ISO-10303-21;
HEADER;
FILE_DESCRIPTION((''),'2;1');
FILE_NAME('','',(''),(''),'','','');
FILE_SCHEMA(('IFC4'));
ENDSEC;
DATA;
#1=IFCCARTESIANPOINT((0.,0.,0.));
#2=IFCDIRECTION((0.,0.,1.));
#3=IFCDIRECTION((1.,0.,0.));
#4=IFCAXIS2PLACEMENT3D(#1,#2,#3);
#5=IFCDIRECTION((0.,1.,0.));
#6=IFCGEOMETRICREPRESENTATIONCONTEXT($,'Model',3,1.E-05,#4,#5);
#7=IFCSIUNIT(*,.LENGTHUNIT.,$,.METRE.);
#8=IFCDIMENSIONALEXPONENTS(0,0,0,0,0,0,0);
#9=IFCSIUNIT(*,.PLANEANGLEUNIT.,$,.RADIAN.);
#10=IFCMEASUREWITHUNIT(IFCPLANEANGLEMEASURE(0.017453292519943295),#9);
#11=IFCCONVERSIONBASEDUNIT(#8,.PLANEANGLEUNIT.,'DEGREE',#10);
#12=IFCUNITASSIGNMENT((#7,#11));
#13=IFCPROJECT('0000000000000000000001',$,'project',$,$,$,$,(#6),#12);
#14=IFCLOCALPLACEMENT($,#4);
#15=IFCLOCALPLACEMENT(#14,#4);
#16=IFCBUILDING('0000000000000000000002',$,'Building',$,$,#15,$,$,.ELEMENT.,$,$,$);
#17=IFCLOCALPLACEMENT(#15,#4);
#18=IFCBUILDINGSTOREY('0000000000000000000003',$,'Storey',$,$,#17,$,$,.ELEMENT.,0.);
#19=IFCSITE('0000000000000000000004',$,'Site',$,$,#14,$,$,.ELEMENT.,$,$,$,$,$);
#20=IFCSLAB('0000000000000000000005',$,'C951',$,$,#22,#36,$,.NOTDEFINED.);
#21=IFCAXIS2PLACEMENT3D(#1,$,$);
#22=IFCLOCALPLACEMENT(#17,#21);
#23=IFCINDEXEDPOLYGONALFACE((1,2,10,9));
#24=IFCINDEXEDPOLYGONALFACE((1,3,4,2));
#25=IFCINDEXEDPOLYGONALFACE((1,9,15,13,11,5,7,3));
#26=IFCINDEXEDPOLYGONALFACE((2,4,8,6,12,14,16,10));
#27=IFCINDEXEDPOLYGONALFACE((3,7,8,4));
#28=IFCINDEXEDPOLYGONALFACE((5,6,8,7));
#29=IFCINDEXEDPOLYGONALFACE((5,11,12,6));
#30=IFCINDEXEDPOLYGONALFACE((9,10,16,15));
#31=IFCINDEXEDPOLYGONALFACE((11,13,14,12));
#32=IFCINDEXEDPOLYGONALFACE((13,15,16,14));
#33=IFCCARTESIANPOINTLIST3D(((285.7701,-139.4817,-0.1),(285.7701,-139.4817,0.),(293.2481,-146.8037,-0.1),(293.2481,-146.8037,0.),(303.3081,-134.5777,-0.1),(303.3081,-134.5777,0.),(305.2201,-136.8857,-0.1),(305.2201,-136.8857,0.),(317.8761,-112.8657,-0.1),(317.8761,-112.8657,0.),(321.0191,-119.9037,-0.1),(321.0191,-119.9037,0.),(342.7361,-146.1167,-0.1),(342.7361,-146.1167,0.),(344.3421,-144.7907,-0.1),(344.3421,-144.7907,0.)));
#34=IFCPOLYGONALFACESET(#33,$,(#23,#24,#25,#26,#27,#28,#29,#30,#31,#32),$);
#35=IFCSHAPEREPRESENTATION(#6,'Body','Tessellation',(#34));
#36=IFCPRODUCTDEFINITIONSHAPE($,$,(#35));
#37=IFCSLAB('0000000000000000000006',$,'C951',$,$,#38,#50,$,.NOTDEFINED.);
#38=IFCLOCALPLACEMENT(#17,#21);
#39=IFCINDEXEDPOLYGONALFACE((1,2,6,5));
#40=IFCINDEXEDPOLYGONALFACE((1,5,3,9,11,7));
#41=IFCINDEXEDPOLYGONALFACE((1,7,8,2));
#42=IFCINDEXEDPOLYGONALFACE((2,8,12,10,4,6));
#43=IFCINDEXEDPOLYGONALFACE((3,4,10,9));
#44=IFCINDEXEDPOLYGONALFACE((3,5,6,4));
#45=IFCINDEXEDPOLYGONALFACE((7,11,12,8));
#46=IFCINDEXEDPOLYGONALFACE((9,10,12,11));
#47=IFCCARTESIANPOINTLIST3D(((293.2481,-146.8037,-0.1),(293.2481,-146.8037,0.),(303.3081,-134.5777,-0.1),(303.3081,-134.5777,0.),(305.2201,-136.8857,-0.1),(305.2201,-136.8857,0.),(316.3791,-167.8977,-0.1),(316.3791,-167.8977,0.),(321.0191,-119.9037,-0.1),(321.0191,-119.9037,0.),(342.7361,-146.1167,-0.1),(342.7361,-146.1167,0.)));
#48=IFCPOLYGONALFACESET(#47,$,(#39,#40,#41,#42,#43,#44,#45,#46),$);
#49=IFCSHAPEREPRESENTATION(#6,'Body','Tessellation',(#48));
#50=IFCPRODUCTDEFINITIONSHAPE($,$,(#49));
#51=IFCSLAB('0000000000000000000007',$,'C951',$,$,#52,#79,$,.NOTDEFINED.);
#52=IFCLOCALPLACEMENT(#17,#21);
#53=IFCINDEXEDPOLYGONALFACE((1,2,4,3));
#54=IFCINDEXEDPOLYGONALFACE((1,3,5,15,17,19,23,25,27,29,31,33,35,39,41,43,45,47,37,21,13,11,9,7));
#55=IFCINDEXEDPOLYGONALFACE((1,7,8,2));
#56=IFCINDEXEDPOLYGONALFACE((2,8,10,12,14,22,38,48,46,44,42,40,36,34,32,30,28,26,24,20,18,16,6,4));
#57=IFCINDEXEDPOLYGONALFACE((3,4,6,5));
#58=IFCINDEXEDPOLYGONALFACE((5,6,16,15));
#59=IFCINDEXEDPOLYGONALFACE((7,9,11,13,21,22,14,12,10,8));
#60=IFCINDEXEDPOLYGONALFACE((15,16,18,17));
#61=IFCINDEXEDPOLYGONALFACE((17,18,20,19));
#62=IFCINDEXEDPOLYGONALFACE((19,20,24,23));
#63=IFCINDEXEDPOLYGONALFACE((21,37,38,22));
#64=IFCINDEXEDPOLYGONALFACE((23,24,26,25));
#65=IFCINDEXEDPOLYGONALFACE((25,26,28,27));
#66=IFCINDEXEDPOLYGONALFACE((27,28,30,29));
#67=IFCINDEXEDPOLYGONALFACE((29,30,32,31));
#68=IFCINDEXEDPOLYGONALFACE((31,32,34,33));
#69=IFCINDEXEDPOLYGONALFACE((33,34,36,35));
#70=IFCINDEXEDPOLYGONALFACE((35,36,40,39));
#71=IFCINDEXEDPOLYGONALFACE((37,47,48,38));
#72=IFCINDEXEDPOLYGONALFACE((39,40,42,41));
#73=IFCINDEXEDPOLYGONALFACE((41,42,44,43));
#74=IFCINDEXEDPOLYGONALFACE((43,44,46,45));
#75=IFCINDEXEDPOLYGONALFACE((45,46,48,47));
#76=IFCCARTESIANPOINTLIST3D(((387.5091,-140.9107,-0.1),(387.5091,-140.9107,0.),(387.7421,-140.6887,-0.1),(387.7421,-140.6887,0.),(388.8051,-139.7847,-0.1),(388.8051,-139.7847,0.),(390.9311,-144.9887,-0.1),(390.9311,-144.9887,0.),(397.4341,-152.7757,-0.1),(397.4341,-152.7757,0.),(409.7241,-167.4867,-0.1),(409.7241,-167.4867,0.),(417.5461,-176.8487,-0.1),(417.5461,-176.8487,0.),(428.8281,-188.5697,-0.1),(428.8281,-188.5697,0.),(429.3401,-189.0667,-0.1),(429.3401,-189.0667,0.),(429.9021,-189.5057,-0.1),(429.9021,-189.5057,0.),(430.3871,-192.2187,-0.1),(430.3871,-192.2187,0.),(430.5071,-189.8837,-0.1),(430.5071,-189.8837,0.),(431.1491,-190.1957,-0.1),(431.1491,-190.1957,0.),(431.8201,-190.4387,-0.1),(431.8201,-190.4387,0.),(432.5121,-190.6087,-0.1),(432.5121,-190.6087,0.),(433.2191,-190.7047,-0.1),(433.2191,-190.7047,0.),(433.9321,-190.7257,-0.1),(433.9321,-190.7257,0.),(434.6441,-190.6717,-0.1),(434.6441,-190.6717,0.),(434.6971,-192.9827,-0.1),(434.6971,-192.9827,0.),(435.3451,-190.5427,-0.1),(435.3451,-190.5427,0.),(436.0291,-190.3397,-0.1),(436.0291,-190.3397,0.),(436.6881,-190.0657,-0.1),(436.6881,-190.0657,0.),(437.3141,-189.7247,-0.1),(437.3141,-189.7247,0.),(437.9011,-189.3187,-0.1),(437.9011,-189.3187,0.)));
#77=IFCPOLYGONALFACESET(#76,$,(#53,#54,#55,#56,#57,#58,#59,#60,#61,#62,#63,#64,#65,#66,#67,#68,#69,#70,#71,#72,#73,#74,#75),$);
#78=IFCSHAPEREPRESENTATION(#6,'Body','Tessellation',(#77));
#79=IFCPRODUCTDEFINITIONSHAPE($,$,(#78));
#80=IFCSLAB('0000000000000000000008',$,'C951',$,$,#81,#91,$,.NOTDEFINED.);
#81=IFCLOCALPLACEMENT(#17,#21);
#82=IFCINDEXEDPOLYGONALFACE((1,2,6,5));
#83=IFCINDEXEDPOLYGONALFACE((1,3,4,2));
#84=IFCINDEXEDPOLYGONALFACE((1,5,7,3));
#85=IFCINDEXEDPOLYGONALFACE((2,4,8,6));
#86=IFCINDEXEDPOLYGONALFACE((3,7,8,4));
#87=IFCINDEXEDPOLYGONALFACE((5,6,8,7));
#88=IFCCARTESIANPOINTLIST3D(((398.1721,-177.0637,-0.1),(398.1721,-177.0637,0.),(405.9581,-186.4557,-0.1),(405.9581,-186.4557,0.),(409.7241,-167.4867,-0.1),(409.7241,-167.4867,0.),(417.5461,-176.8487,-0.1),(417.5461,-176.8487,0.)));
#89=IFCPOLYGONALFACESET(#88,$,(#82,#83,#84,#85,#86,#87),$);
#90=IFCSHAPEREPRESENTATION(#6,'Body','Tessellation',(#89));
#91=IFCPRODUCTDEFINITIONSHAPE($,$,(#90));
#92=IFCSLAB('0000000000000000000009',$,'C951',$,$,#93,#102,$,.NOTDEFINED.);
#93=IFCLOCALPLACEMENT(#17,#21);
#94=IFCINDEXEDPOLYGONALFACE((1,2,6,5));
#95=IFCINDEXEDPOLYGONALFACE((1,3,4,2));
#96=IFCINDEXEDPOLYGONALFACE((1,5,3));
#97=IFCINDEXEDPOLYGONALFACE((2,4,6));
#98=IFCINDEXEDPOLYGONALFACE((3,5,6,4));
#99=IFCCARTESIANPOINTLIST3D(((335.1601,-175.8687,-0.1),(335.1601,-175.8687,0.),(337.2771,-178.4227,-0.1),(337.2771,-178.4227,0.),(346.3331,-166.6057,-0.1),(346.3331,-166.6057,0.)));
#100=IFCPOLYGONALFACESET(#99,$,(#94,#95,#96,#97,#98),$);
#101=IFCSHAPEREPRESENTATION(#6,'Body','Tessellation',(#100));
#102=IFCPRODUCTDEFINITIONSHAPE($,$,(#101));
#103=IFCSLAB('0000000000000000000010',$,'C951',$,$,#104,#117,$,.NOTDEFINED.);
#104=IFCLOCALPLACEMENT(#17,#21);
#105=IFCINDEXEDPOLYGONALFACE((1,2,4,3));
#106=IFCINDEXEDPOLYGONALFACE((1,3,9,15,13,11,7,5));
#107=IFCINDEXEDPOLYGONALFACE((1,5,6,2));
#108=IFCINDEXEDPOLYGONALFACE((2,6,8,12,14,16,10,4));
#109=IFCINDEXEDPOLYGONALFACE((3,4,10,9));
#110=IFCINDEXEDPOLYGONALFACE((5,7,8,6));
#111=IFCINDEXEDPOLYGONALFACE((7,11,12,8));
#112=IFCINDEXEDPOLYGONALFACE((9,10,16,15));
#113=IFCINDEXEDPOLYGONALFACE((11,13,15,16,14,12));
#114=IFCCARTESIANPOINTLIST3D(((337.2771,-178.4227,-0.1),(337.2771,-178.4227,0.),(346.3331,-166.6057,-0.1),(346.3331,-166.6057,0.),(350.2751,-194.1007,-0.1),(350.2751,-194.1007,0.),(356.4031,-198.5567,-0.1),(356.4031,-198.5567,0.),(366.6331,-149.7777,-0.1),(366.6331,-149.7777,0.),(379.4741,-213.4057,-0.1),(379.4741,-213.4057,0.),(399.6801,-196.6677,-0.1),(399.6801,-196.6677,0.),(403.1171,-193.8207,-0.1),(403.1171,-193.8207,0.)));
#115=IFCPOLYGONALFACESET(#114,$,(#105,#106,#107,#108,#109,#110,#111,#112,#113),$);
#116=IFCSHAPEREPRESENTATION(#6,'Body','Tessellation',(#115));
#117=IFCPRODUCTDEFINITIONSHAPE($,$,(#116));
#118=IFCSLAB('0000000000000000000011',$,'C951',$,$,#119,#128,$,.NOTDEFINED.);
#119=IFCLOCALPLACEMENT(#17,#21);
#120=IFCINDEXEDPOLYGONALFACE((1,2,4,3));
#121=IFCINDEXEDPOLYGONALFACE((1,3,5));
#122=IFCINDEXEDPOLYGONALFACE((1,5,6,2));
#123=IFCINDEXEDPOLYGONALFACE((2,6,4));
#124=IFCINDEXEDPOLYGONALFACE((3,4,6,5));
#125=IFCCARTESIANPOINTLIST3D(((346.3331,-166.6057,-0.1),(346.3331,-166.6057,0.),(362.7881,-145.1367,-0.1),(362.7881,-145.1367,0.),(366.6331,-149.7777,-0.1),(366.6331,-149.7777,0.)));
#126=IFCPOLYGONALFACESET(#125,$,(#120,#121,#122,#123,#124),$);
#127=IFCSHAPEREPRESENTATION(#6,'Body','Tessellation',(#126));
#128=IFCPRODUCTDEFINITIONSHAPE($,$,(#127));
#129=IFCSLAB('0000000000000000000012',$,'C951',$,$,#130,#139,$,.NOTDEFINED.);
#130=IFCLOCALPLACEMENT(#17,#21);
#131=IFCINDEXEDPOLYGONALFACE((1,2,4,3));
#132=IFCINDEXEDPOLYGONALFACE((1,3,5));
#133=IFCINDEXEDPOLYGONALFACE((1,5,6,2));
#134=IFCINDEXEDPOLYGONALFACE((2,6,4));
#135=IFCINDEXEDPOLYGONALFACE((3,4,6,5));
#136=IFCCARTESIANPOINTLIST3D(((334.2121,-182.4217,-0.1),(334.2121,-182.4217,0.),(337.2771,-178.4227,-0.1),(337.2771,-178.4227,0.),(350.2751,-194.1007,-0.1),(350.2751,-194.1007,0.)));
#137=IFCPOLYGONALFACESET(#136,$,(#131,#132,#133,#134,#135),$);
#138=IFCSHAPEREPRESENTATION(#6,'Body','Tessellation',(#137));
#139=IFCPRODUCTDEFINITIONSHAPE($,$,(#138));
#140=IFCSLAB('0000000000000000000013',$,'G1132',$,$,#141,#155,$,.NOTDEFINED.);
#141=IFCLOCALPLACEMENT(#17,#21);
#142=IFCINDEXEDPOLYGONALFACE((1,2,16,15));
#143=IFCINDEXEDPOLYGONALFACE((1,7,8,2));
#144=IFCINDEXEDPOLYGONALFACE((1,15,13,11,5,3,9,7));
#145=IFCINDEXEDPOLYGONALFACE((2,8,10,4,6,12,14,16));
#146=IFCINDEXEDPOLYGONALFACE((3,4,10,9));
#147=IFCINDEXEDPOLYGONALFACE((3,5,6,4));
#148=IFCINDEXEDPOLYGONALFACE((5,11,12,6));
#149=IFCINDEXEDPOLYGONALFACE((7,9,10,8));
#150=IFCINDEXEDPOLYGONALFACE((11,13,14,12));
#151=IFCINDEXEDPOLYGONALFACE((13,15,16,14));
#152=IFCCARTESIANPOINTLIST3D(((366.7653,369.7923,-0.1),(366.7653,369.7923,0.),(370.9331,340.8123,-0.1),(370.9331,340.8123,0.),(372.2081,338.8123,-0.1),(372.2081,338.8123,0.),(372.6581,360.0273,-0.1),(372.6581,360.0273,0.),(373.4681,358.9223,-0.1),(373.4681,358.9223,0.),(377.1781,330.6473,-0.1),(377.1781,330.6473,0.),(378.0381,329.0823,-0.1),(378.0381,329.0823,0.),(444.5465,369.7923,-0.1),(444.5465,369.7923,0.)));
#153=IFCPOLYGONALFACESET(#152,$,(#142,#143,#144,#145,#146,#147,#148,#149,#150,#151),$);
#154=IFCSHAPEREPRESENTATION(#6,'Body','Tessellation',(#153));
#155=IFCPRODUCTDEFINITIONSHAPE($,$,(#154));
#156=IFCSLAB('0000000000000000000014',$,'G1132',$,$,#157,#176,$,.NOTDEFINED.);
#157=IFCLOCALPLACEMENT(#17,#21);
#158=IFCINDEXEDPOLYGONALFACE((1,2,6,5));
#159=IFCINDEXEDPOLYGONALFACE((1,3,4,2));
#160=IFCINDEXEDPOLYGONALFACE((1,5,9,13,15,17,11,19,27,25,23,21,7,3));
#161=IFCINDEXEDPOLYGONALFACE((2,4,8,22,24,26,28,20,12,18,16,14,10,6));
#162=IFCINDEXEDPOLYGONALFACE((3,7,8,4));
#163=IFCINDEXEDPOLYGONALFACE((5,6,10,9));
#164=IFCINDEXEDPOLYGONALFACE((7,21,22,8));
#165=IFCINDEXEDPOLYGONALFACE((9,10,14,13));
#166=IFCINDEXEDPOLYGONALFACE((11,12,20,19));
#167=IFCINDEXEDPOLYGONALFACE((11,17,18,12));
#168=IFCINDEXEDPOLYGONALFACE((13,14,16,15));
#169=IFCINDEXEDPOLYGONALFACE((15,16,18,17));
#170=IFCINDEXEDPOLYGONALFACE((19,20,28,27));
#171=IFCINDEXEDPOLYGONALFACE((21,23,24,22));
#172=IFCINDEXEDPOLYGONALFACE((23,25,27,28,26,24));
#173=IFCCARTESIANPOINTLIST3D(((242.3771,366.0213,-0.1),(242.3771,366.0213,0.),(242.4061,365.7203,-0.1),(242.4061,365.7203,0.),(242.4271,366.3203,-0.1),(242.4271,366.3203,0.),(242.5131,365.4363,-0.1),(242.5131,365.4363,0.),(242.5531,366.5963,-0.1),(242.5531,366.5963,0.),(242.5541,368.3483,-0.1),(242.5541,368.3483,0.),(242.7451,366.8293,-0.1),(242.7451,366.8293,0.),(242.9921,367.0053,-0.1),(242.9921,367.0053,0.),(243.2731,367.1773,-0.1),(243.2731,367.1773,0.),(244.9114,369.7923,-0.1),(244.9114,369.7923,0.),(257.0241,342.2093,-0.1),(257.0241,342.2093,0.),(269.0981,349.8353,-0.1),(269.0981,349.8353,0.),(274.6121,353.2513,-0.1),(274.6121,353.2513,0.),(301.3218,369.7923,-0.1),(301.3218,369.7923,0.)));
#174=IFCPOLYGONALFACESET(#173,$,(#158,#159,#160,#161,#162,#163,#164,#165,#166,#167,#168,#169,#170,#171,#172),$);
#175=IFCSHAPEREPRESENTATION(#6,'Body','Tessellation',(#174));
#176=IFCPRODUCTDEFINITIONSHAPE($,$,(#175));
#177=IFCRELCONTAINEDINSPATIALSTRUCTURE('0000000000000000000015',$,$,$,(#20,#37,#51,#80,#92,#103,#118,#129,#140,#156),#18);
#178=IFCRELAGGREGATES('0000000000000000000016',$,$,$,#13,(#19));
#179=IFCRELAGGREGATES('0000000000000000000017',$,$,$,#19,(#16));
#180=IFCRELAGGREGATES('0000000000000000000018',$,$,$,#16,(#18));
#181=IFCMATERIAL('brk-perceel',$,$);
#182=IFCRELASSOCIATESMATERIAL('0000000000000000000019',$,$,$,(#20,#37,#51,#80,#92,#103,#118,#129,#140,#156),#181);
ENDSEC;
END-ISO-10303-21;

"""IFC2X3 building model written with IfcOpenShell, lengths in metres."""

from ifc_helpers import new_model, entity, si_unit, converted_unit, direction, frame, origin_with_axes, place, context, project, spatial, polyline, outline, extrude, material, element, save


model = new_model("IFC2X3")

# Units and contexts
model_context = context("Model", 3, precision=1e-05, world=origin_with_axes(), true_north=direction((0.0, 1.0, 0.0)))
ifc_project = project(units=[si_unit("LENGTHUNIT", "METRE"), converted_unit("PLANEANGLEUNIT", "DEGREE", entity("IfcPlaneAngleMeasure", 0.017453292519943295), si_unit("PLANEANGLEUNIT", "RADIAN"), dimensions=[0, 0, 0, 0, 0, 0, 0])], contexts=[model_context])

# Site, building, storey
site_placement = place(None, origin_with_axes())
site = spatial("IfcSite", under=ifc_project, at=site_placement, Name="Site", CompositionType="ELEMENT")
building_placement = place(site_placement, origin_with_axes())
building = spatial("IfcBuilding", under=site, at=building_placement, Name="Building", CompositionType="ELEMENT")
storey_placement = place(building_placement, origin_with_axes())
storey = spatial("IfcBuildingStorey", under=building, at=storey_placement, Name="Storey", CompositionType="ELEMENT", Elevation=0.0)

# Slabs
ifc_material = material(Name="brk-perceel")
slab_1_placement = place(storey_placement, frame((0.0, 0.0, -0.1), z_axis=(0.0, 0.0, 1.0), x_axis=(1.0, 0.0, 0.0)))
element("IfcSlab", 1, at=slab_1_placement, inside=storey, material=ifc_material, Name="C951", PredefinedType="NOTDEFINED", context=model_context, shape_type="SweptSolid", body=[
    extrude(outline(polyline([(342.7361, -146.1167), (321.0191, -119.9037), (303.3081, -134.5777), (305.2201, -136.8857), (293.2481, -146.8037), (285.7701, -139.4817), (317.8761, -112.8657), (344.3421, -144.7907), (342.7361, -146.1167)])), origin_with_axes(), (0.0, 0.0, 1.0), 0.1),
])
slab_2_placement = place(storey_placement, frame((0.0, 0.0, -0.1), z_axis=(0.0, 0.0, 1.0), x_axis=(1.0, 0.0, 0.0)))
element("IfcSlab", 2, at=slab_2_placement, inside=storey, material=ifc_material, Name="C951", PredefinedType="NOTDEFINED", context=model_context, shape_type="SweptSolid", body=[
    extrude(outline(polyline([(316.3791, -167.8977), (293.2481, -146.8037), (305.2201, -136.8857), (303.3081, -134.5777), (321.0191, -119.9037), (342.7361, -146.1167), (316.3791, -167.8977)])), origin_with_axes(), (0.0, 0.0, 1.0), 0.1),
])
slab_3_placement = place(storey_placement, frame((0.0, 0.0, -0.1), z_axis=(0.0, 0.0, 1.0), x_axis=(1.0, 0.0, 0.0)))
element("IfcSlab", 3, at=slab_3_placement, inside=storey, material=ifc_material, Name="C951", PredefinedType="NOTDEFINED", context=model_context, shape_type="SweptSolid", body=[
    extrude(outline(polyline([(429.3401, -189.0667), (429.9021, -189.5057), (430.5071, -189.8837), (431.1491, -190.1957), (431.8201, -190.4387), (432.5121, -190.6087), (433.2191, -190.7047), (433.9321, -190.7257), (434.6441, -190.6717), (435.3451, -190.5427), (436.0291, -190.3397), (436.6881, -190.0657), (437.3141, -189.7247), (437.9011, -189.3187), (434.6971, -192.9827), (430.3871, -192.2187), (417.5461, -176.8487), (409.7241, -167.4867), (397.4341, -152.7757), (390.9311, -144.9887), (387.5091, -140.9107), (387.7421, -140.6887), (388.8051, -139.7847), (428.8281, -188.5697), (429.3401, -189.0667)])), origin_with_axes(), (0.0, 0.0, 1.0), 0.1),
])
slab_4_placement = place(storey_placement, frame((0.0, 0.0, -0.1), z_axis=(0.0, 0.0, 1.0), x_axis=(1.0, 0.0, 0.0)))
element("IfcSlab", 4, at=slab_4_placement, inside=storey, material=ifc_material, Name="C951", PredefinedType="NOTDEFINED", context=model_context, shape_type="SweptSolid", body=[
    extrude(outline(polyline([(417.5461, -176.8487), (405.9581, -186.4557), (398.1721, -177.0637), (409.7241, -167.4867), (417.5461, -176.8487)])), origin_with_axes(), (0.0, 0.0, 1.0), 0.1),
])
slab_5_placement = place(storey_placement, frame((0.0, 0.0, -0.1), z_axis=(0.0, 0.0, 1.0), x_axis=(1.0, 0.0, 0.0)))
element("IfcSlab", 5, at=slab_5_placement, inside=storey, material=ifc_material, Name="C951", PredefinedType="NOTDEFINED", context=model_context, shape_type="SweptSolid", body=[
    extrude(outline(polyline([(346.3331, -166.6057), (337.2771, -178.4227), (335.1601, -175.8687), (346.3331, -166.6057)])), origin_with_axes(), (0.0, 0.0, 1.0), 0.1),
])
slab_6_placement = place(storey_placement, frame((0.0, 0.0, -0.1), z_axis=(0.0, 0.0, 1.0), x_axis=(1.0, 0.0, 0.0)))
element("IfcSlab", 6, at=slab_6_placement, inside=storey, material=ifc_material, Name="C951", PredefinedType="NOTDEFINED", context=model_context, shape_type="SweptSolid", body=[
    extrude(outline(polyline([(366.6331, -149.7777), (403.1171, -193.8207), (399.6801, -196.6677), (379.4741, -213.4057), (356.4031, -198.5567), (350.2751, -194.1007), (337.2771, -178.4227), (346.3331, -166.6057), (366.6331, -149.7777)])), origin_with_axes(), (0.0, 0.0, 1.0), 0.1),
])
slab_7_placement = place(storey_placement, frame((0.0, 0.0, -0.1), z_axis=(0.0, 0.0, 1.0), x_axis=(1.0, 0.0, 0.0)))
element("IfcSlab", 7, at=slab_7_placement, inside=storey, material=ifc_material, Name="C951", PredefinedType="NOTDEFINED", context=model_context, shape_type="SweptSolid", body=[
    extrude(outline(polyline([(366.6331, -149.7777), (346.3331, -166.6057), (362.7881, -145.1367), (366.6331, -149.7777)])), origin_with_axes(), (0.0, 0.0, 1.0), 0.1),
])
slab_8_placement = place(storey_placement, frame((0.0, 0.0, -0.1), z_axis=(0.0, 0.0, 1.0), x_axis=(1.0, 0.0, 0.0)))
element("IfcSlab", 8, at=slab_8_placement, inside=storey, material=ifc_material, Name="C951", PredefinedType="NOTDEFINED", context=model_context, shape_type="SweptSolid", body=[
    extrude(outline(polyline([(350.2751, -194.1007), (334.2121, -182.4217), (337.2771, -178.4227), (350.2751, -194.1007)])), origin_with_axes(), (0.0, 0.0, 1.0), 0.1),
])
slab_9_placement = place(storey_placement, frame((0.0, 0.0, -0.1), z_axis=(0.0, 0.0, 1.0), x_axis=(1.0, 0.0, 0.0)))
element("IfcSlab", 9, at=slab_9_placement, inside=storey, material=ifc_material, Name="G1132", PredefinedType="NOTDEFINED", context=model_context, shape_type="SweptSolid", body=[
    extrude(outline(polyline([(378.0381, 329.0823), (377.1781, 330.6473), (372.2081, 338.8123), (370.9331, 340.8123), (373.4681, 358.9223), (372.6581, 360.0273), (366.7653, 369.7923), (444.5465, 369.7923), (378.0381, 329.0823)])), origin_with_axes(), (0.0, 0.0, 1.0), 0.1),
])
slab_10_placement = place(storey_placement, frame((0.0, 0.0, -0.1), z_axis=(0.0, 0.0, 1.0), x_axis=(1.0, 0.0, 0.0)))
element("IfcSlab", 10, at=slab_10_placement, inside=storey, material=ifc_material, Name="G1132", PredefinedType="NOTDEFINED", context=model_context, shape_type="SweptSolid", body=[
    extrude(outline(polyline([(274.6121, 353.2513), (269.0981, 349.8353), (257.0241, 342.2093), (242.5131, 365.4363), (242.4061, 365.7203), (242.3771, 366.0213), (242.4271, 366.3203), (242.5531, 366.5963), (242.7451, 366.8293), (242.9921, 367.0053), (243.2731, 367.1773), (242.5541, 368.3483), (244.9114, 369.7923), (301.3218, 369.7923), (274.6121, 353.2513)])), origin_with_axes(), (0.0, 0.0, 1.0), 0.1),
])

save(model, "model.ifc")
